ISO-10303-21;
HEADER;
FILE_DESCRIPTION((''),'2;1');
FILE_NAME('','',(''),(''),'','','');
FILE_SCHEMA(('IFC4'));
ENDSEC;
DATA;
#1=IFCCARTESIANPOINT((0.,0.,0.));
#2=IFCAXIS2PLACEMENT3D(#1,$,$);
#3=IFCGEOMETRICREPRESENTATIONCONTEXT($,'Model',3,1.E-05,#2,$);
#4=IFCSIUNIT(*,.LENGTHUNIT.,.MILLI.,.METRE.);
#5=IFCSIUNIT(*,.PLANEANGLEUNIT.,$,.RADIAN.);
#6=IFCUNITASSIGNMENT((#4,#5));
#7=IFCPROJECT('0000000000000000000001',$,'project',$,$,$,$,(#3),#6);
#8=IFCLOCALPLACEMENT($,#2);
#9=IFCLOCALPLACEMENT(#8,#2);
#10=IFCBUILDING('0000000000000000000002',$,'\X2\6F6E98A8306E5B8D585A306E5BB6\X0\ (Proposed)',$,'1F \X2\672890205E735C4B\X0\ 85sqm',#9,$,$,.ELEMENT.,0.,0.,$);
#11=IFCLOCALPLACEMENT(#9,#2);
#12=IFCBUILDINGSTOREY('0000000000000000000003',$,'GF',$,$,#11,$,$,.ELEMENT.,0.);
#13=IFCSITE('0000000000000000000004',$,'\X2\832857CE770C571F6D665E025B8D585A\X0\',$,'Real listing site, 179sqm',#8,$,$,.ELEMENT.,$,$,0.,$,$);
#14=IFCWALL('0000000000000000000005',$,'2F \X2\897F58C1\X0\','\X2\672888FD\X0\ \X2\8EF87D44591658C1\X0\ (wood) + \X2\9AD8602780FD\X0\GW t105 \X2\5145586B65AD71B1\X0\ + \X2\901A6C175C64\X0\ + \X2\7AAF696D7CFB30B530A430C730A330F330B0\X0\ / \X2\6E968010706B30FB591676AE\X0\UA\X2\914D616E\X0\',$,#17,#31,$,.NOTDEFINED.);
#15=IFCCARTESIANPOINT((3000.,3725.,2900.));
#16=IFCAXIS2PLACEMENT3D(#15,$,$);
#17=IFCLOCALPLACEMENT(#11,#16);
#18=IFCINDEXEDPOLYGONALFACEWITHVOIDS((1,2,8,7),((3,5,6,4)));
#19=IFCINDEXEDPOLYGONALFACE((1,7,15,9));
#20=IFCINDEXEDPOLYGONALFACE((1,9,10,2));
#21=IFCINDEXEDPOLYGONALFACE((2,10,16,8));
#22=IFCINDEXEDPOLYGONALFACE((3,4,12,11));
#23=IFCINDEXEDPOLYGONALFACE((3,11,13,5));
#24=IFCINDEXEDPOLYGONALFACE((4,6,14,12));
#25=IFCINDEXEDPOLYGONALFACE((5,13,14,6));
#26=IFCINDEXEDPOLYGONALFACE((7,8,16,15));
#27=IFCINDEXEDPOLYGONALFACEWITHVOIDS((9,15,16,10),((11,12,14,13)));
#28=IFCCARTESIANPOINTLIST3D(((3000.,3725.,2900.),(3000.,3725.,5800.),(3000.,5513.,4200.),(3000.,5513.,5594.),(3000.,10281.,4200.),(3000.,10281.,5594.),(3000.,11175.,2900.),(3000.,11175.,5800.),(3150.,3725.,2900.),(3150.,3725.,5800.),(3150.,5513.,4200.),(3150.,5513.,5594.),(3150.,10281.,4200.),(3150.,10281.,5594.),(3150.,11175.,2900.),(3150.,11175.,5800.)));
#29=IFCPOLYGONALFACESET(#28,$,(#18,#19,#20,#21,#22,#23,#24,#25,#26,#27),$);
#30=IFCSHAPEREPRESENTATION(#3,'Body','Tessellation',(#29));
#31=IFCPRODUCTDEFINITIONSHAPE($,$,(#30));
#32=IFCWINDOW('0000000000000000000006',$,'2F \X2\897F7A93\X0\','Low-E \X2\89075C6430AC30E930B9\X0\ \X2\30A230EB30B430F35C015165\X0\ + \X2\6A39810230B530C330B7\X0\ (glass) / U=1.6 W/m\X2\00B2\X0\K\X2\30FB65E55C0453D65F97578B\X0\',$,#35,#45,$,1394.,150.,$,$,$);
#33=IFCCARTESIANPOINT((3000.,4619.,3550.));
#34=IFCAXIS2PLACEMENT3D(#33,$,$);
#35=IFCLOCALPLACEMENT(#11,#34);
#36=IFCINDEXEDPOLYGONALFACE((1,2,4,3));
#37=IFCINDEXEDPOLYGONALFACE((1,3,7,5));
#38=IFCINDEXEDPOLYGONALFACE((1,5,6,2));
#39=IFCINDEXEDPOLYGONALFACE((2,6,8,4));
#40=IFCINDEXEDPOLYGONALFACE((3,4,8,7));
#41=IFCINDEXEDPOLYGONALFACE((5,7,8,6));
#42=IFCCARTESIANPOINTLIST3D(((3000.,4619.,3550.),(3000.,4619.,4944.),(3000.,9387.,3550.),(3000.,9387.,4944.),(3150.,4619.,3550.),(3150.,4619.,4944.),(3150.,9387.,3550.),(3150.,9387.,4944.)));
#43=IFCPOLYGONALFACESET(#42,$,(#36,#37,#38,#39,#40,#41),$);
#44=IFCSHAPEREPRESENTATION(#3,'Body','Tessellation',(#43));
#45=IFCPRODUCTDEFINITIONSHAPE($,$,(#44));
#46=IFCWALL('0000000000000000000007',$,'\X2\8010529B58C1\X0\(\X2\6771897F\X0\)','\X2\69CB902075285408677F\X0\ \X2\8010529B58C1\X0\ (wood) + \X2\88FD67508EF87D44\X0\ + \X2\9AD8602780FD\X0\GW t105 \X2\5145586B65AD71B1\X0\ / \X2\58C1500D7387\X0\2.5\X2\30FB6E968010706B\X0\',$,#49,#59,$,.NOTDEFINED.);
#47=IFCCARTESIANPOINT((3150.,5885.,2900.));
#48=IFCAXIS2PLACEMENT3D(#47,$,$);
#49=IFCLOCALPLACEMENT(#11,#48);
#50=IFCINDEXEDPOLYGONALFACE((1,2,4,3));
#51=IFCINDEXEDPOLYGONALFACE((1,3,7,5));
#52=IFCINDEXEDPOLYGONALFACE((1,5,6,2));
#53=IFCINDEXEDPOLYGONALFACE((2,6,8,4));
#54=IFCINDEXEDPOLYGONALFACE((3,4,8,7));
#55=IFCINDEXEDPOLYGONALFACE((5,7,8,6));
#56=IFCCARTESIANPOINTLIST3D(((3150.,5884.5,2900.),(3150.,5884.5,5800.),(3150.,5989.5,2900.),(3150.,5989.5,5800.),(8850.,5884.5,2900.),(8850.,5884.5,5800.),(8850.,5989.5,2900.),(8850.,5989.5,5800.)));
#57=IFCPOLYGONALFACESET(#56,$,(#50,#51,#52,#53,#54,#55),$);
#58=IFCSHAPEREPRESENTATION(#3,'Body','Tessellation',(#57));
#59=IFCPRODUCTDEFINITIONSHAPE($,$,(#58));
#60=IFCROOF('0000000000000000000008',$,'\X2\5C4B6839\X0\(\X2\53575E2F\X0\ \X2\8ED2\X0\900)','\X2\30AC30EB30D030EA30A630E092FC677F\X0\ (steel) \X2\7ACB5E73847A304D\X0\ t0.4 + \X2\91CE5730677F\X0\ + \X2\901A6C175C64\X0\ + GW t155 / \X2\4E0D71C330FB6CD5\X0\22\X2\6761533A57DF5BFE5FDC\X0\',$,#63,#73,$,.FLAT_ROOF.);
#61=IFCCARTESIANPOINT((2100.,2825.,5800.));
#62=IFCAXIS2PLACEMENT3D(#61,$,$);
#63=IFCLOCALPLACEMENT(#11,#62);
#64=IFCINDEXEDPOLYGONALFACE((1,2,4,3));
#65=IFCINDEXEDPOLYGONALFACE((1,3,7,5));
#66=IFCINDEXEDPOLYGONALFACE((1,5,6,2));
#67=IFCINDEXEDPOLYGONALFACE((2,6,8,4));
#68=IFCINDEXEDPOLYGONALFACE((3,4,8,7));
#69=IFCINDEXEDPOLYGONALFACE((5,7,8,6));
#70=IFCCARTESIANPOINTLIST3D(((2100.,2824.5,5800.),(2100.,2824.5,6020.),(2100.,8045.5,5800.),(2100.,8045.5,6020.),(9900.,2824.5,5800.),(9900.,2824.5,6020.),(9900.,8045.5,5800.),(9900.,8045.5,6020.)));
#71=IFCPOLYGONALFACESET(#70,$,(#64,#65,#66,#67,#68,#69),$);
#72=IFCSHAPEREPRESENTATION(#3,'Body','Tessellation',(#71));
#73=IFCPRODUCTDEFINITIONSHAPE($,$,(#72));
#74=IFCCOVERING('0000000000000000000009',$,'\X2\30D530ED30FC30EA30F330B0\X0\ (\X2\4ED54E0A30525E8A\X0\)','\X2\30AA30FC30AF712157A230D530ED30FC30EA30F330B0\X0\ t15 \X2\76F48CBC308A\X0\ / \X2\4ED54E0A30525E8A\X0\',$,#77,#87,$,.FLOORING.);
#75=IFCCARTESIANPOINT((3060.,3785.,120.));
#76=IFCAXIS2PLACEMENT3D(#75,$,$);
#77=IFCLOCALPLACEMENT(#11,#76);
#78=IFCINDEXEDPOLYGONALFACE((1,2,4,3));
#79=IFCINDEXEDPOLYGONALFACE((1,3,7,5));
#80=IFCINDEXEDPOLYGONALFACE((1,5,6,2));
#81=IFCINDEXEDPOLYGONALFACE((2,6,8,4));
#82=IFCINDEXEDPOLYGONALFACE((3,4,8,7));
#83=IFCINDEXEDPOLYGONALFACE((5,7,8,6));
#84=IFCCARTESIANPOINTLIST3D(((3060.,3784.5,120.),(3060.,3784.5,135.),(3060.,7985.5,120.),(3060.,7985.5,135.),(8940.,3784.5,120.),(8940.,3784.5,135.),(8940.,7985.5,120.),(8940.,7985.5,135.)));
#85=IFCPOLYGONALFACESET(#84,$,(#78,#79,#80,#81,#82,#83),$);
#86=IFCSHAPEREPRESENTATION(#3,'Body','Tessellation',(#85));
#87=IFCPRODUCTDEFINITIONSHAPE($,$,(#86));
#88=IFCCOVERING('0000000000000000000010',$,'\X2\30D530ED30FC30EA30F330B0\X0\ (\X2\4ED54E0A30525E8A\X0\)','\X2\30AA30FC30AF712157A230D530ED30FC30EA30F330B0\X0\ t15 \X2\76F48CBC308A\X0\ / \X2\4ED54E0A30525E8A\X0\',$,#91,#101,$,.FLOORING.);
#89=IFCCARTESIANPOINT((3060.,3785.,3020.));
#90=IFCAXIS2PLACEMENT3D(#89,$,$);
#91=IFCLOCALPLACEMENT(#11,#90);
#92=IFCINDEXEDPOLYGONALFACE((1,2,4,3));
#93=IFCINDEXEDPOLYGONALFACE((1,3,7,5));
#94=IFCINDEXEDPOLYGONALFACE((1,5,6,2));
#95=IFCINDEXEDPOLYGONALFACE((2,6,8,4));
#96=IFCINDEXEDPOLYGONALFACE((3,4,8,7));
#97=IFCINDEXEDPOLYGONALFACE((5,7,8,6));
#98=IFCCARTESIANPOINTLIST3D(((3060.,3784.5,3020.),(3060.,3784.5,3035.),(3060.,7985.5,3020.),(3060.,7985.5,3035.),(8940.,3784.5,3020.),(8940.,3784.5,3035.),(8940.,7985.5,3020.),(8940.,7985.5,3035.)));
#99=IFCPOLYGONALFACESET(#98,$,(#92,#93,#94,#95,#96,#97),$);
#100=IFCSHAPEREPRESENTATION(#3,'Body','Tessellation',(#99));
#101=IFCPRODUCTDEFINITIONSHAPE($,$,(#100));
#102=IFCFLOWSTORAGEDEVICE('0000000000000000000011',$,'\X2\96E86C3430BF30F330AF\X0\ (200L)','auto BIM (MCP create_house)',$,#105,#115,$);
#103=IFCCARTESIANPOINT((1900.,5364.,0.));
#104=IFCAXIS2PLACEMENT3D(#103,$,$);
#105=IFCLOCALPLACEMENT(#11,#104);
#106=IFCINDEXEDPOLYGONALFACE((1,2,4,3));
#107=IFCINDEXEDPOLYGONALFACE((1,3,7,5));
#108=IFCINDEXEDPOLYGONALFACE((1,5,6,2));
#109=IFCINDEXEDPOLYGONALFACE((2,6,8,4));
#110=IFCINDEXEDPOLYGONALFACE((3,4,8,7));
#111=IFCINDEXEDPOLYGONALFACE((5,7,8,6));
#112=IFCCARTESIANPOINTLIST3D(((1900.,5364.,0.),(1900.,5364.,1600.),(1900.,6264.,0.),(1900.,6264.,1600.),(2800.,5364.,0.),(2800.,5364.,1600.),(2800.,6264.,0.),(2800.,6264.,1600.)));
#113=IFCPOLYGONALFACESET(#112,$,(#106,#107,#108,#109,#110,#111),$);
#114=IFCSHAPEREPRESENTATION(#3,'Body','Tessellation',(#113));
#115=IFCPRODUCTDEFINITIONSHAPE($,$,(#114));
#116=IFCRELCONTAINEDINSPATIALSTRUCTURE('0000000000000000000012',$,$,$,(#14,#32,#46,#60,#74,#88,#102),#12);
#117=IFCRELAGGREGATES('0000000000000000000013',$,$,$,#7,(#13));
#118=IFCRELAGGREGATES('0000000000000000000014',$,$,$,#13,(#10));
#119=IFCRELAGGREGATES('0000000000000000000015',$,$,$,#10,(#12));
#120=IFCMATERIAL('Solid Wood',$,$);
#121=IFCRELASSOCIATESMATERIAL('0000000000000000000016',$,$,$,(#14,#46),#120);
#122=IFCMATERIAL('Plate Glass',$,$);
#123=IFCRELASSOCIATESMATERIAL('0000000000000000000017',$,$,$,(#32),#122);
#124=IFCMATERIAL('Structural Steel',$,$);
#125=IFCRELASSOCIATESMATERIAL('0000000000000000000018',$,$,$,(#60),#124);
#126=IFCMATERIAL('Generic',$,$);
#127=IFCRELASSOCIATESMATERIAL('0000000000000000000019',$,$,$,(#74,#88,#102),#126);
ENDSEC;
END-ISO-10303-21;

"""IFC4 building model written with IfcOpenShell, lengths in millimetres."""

from ifc_helpers import new_model, si_unit, frame, frame_2d, origin, place, context, project, spatial, rectangle, extrude, material, element, fill, save


model = new_model("IFC4")

# Units and contexts
model_context = context("Model", 3, precision=1e-05, world=origin())
ifc_project = project(units=[si_unit("LENGTHUNIT", "METRE", prefix="MILLI"), si_unit("PLANEANGLEUNIT", "RADIAN")], contexts=[model_context])

# Site, building, storey
site_placement = place(None, origin())
site = spatial("IfcSite", under=ifc_project, at=site_placement, Name="茨城県土浦市宍塚", ObjectType="Real listing site, 179sqm", CompositionType="ELEMENT", RefElevation=0.0)
building_placement = place(site_placement, origin())
building = spatial("IfcBuilding", under=site, at=building_placement, Name="潮風の宍塚の家 (Proposed)", ObjectType="1F 木造平屋 85sqm", CompositionType="ELEMENT", ElevationOfRefHeight=0.0, ElevationOfTerrain=0.0)
storey_placement = place(building_placement, origin())
storey = spatial("IfcBuildingStorey", under=building, at=storey_placement, Name="GF", CompositionType="ELEMENT", Elevation=0.0)

# Shared definitions
ifc_material_1 = material(Name="Solid Wood")
ifc_material_2 = material(Name="Generic")

# Shared definitions
ifc_material_3 = material(Name="Plate Glass")

# Wall, opening, window
wall_1_placement = place(storey_placement, frame((3000.0, 3725.0, 2900.0)))
wall_1 = element("IfcWall", 1, at=wall_1_placement, inside=storey, material=ifc_material_1, Name="2F 西壁", Description="木製 軸組外壁 (wood) + 高性能GW t105 充填断熱 + 通気層 + 窯業系サイディング / 準耐火・外皮UA配慮", PredefinedType="NOTDEFINED", context=model_context, shape_type="SweptSolid", body=[
    extrude(rectangle(XDim=150.0, YDim=7450.0, at=frame_2d((75.0, 3725.0))), frame((3000.0, 3725.0, 2900.0)), (0.0, 0.0, 1.0), 2900.0),
])
opening_1_placement = place(storey_placement, frame((3000.0, 4619.0, 3550.0)))
opening_1 = element("IfcOpeningElement", 2, at=opening_1_placement, cuts=wall_1, PredefinedType="NOTDEFINED", context=model_context, shape_type="SweptSolid", body=[
    extrude(rectangle(XDim=150.0, YDim=4768.0, at=frame_2d((75.0, 2384.0))), frame((3000.0, 4619.0, 3550.0)), (0.0, 0.0, 1.0), 1394.0),
])
window_1_placement = place(storey_placement, frame((3000.0, 4619.0, 3550.0)))
window_1 = element("IfcWindow", 3, at=window_1_placement, inside=storey, material=ifc_material_3, Name="2F 西窓", Description="Low-E 複層ガラス アルゴン封入 + 樹脂サッシ (glass) / U=1.6 W/m²K・日射取得型", OverallHeight=1394.0, OverallWidth=150.0, context=model_context, shape_type="SweptSolid", body=[
    extrude(rectangle(XDim=150.0, YDim=4768.0, at=frame_2d((75.0, 2384.0))), frame((3000.0, 4619.0, 3550.0)), (0.0, 0.0, 1.0), 1394.0),
])
fill(opening_1, window_1)

# Wall
wall_2_placement = place(storey_placement, frame((3150.0, 5885.0, 2900.0)))
element("IfcWall", 4, at=wall_2_placement, inside=storey, material=ifc_material_1, Name="耐力壁(東西)", Description="構造用合板 耐力壁 (wood) + 製材軸組 + 高性能GW t105 充填断熱 / 壁倍率2.5・準耐火", PredefinedType="NOTDEFINED", context=model_context, shape_type="SweptSolid", body=[
    extrude(rectangle(XDim=5700.0, YDim=105.0, at=frame_2d((2850.0, 52.0))), frame((3150.0, 5885.0, 2900.0)), (0.0, 0.0, 1.0), 2900.0),
])

# Roof
ifc_material_4 = material(Name="Structural Steel")
for number, where, name in (
    (5, (2100.0, 2825.0, 5800.0), "屋根(南帯 軒900)"),
):
    element("IfcRoof", number, at=place(storey_placement, frame(where)), inside=storey, material=ifc_material_4, Name=name, Description="ガルバリウム鋼板 (steel) 立平葺き t0.4 + 野地板 + 通気層 + GW t155 / 不燃・法22条区域対応", PredefinedType="FLAT_ROOF", context=model_context, shape_type="SweptSolid", body=[
        extrude(rectangle(XDim=7800.0, YDim=5221.0, at=frame_2d((3900.0, 2610.0))), frame((2100.0, 2825.0, 5800.0)), (0.0, 0.0, 1.0), 220.0),
    ])

# Coverings
covering_1_placement = place(storey_placement, frame((3060.0, 3785.0, 120.0)))
element("IfcCovering", 6, at=covering_1_placement, inside=storey, material=ifc_material_2, Name="フローリング (仕上げ床)", Description="オーク無垢フローリング t15 直貼り / 仕上げ床", PredefinedType="FLOORING", context=model_context, shape_type="SweptSolid", body=[
    extrude(rectangle(XDim=5880.0, YDim=4201.0, at=frame_2d((2940.0, 2100.0))), frame((3060.0, 3785.0, 120.0)), (0.0, 0.0, 1.0), 15.0),
])
covering_2_placement = place(storey_placement, frame((3060.0, 3785.0, 3020.0)))
element("IfcCovering", 7, at=covering_2_placement, inside=storey, material=ifc_material_2, Name="フローリング (仕上げ床)", Description="オーク無垢フローリング t15 直貼り / 仕上げ床", PredefinedType="FLOORING", context=model_context, shape_type="SweptSolid", body=[
    extrude(rectangle(XDim=5880.0, YDim=4201.0, at=frame_2d((2940.0, 2100.0))), frame((3060.0, 3785.0, 3020.0)), (0.0, 0.0, 1.0), 15.0),
])

# Flow storage device
flow_storage_device_placement = place(storey_placement, frame((1900.0, 5364.0, 0.0)))
element("IfcFlowStorageDevice", 8, at=flow_storage_device_placement, inside=storey, material=ifc_material_2, Name="雨水タンク (200L)", Description="auto BIM (MCP create_house)", context=model_context, shape_type="SweptSolid", body=[
    extrude(rectangle(XDim=900.0, YDim=900.0, at=frame_2d((450.0, 450.0))), frame((1900.0, 5364.0, 0.0)), (0.0, 0.0, 1.0), 1600.0),
])

save(model, "model.ifc")
